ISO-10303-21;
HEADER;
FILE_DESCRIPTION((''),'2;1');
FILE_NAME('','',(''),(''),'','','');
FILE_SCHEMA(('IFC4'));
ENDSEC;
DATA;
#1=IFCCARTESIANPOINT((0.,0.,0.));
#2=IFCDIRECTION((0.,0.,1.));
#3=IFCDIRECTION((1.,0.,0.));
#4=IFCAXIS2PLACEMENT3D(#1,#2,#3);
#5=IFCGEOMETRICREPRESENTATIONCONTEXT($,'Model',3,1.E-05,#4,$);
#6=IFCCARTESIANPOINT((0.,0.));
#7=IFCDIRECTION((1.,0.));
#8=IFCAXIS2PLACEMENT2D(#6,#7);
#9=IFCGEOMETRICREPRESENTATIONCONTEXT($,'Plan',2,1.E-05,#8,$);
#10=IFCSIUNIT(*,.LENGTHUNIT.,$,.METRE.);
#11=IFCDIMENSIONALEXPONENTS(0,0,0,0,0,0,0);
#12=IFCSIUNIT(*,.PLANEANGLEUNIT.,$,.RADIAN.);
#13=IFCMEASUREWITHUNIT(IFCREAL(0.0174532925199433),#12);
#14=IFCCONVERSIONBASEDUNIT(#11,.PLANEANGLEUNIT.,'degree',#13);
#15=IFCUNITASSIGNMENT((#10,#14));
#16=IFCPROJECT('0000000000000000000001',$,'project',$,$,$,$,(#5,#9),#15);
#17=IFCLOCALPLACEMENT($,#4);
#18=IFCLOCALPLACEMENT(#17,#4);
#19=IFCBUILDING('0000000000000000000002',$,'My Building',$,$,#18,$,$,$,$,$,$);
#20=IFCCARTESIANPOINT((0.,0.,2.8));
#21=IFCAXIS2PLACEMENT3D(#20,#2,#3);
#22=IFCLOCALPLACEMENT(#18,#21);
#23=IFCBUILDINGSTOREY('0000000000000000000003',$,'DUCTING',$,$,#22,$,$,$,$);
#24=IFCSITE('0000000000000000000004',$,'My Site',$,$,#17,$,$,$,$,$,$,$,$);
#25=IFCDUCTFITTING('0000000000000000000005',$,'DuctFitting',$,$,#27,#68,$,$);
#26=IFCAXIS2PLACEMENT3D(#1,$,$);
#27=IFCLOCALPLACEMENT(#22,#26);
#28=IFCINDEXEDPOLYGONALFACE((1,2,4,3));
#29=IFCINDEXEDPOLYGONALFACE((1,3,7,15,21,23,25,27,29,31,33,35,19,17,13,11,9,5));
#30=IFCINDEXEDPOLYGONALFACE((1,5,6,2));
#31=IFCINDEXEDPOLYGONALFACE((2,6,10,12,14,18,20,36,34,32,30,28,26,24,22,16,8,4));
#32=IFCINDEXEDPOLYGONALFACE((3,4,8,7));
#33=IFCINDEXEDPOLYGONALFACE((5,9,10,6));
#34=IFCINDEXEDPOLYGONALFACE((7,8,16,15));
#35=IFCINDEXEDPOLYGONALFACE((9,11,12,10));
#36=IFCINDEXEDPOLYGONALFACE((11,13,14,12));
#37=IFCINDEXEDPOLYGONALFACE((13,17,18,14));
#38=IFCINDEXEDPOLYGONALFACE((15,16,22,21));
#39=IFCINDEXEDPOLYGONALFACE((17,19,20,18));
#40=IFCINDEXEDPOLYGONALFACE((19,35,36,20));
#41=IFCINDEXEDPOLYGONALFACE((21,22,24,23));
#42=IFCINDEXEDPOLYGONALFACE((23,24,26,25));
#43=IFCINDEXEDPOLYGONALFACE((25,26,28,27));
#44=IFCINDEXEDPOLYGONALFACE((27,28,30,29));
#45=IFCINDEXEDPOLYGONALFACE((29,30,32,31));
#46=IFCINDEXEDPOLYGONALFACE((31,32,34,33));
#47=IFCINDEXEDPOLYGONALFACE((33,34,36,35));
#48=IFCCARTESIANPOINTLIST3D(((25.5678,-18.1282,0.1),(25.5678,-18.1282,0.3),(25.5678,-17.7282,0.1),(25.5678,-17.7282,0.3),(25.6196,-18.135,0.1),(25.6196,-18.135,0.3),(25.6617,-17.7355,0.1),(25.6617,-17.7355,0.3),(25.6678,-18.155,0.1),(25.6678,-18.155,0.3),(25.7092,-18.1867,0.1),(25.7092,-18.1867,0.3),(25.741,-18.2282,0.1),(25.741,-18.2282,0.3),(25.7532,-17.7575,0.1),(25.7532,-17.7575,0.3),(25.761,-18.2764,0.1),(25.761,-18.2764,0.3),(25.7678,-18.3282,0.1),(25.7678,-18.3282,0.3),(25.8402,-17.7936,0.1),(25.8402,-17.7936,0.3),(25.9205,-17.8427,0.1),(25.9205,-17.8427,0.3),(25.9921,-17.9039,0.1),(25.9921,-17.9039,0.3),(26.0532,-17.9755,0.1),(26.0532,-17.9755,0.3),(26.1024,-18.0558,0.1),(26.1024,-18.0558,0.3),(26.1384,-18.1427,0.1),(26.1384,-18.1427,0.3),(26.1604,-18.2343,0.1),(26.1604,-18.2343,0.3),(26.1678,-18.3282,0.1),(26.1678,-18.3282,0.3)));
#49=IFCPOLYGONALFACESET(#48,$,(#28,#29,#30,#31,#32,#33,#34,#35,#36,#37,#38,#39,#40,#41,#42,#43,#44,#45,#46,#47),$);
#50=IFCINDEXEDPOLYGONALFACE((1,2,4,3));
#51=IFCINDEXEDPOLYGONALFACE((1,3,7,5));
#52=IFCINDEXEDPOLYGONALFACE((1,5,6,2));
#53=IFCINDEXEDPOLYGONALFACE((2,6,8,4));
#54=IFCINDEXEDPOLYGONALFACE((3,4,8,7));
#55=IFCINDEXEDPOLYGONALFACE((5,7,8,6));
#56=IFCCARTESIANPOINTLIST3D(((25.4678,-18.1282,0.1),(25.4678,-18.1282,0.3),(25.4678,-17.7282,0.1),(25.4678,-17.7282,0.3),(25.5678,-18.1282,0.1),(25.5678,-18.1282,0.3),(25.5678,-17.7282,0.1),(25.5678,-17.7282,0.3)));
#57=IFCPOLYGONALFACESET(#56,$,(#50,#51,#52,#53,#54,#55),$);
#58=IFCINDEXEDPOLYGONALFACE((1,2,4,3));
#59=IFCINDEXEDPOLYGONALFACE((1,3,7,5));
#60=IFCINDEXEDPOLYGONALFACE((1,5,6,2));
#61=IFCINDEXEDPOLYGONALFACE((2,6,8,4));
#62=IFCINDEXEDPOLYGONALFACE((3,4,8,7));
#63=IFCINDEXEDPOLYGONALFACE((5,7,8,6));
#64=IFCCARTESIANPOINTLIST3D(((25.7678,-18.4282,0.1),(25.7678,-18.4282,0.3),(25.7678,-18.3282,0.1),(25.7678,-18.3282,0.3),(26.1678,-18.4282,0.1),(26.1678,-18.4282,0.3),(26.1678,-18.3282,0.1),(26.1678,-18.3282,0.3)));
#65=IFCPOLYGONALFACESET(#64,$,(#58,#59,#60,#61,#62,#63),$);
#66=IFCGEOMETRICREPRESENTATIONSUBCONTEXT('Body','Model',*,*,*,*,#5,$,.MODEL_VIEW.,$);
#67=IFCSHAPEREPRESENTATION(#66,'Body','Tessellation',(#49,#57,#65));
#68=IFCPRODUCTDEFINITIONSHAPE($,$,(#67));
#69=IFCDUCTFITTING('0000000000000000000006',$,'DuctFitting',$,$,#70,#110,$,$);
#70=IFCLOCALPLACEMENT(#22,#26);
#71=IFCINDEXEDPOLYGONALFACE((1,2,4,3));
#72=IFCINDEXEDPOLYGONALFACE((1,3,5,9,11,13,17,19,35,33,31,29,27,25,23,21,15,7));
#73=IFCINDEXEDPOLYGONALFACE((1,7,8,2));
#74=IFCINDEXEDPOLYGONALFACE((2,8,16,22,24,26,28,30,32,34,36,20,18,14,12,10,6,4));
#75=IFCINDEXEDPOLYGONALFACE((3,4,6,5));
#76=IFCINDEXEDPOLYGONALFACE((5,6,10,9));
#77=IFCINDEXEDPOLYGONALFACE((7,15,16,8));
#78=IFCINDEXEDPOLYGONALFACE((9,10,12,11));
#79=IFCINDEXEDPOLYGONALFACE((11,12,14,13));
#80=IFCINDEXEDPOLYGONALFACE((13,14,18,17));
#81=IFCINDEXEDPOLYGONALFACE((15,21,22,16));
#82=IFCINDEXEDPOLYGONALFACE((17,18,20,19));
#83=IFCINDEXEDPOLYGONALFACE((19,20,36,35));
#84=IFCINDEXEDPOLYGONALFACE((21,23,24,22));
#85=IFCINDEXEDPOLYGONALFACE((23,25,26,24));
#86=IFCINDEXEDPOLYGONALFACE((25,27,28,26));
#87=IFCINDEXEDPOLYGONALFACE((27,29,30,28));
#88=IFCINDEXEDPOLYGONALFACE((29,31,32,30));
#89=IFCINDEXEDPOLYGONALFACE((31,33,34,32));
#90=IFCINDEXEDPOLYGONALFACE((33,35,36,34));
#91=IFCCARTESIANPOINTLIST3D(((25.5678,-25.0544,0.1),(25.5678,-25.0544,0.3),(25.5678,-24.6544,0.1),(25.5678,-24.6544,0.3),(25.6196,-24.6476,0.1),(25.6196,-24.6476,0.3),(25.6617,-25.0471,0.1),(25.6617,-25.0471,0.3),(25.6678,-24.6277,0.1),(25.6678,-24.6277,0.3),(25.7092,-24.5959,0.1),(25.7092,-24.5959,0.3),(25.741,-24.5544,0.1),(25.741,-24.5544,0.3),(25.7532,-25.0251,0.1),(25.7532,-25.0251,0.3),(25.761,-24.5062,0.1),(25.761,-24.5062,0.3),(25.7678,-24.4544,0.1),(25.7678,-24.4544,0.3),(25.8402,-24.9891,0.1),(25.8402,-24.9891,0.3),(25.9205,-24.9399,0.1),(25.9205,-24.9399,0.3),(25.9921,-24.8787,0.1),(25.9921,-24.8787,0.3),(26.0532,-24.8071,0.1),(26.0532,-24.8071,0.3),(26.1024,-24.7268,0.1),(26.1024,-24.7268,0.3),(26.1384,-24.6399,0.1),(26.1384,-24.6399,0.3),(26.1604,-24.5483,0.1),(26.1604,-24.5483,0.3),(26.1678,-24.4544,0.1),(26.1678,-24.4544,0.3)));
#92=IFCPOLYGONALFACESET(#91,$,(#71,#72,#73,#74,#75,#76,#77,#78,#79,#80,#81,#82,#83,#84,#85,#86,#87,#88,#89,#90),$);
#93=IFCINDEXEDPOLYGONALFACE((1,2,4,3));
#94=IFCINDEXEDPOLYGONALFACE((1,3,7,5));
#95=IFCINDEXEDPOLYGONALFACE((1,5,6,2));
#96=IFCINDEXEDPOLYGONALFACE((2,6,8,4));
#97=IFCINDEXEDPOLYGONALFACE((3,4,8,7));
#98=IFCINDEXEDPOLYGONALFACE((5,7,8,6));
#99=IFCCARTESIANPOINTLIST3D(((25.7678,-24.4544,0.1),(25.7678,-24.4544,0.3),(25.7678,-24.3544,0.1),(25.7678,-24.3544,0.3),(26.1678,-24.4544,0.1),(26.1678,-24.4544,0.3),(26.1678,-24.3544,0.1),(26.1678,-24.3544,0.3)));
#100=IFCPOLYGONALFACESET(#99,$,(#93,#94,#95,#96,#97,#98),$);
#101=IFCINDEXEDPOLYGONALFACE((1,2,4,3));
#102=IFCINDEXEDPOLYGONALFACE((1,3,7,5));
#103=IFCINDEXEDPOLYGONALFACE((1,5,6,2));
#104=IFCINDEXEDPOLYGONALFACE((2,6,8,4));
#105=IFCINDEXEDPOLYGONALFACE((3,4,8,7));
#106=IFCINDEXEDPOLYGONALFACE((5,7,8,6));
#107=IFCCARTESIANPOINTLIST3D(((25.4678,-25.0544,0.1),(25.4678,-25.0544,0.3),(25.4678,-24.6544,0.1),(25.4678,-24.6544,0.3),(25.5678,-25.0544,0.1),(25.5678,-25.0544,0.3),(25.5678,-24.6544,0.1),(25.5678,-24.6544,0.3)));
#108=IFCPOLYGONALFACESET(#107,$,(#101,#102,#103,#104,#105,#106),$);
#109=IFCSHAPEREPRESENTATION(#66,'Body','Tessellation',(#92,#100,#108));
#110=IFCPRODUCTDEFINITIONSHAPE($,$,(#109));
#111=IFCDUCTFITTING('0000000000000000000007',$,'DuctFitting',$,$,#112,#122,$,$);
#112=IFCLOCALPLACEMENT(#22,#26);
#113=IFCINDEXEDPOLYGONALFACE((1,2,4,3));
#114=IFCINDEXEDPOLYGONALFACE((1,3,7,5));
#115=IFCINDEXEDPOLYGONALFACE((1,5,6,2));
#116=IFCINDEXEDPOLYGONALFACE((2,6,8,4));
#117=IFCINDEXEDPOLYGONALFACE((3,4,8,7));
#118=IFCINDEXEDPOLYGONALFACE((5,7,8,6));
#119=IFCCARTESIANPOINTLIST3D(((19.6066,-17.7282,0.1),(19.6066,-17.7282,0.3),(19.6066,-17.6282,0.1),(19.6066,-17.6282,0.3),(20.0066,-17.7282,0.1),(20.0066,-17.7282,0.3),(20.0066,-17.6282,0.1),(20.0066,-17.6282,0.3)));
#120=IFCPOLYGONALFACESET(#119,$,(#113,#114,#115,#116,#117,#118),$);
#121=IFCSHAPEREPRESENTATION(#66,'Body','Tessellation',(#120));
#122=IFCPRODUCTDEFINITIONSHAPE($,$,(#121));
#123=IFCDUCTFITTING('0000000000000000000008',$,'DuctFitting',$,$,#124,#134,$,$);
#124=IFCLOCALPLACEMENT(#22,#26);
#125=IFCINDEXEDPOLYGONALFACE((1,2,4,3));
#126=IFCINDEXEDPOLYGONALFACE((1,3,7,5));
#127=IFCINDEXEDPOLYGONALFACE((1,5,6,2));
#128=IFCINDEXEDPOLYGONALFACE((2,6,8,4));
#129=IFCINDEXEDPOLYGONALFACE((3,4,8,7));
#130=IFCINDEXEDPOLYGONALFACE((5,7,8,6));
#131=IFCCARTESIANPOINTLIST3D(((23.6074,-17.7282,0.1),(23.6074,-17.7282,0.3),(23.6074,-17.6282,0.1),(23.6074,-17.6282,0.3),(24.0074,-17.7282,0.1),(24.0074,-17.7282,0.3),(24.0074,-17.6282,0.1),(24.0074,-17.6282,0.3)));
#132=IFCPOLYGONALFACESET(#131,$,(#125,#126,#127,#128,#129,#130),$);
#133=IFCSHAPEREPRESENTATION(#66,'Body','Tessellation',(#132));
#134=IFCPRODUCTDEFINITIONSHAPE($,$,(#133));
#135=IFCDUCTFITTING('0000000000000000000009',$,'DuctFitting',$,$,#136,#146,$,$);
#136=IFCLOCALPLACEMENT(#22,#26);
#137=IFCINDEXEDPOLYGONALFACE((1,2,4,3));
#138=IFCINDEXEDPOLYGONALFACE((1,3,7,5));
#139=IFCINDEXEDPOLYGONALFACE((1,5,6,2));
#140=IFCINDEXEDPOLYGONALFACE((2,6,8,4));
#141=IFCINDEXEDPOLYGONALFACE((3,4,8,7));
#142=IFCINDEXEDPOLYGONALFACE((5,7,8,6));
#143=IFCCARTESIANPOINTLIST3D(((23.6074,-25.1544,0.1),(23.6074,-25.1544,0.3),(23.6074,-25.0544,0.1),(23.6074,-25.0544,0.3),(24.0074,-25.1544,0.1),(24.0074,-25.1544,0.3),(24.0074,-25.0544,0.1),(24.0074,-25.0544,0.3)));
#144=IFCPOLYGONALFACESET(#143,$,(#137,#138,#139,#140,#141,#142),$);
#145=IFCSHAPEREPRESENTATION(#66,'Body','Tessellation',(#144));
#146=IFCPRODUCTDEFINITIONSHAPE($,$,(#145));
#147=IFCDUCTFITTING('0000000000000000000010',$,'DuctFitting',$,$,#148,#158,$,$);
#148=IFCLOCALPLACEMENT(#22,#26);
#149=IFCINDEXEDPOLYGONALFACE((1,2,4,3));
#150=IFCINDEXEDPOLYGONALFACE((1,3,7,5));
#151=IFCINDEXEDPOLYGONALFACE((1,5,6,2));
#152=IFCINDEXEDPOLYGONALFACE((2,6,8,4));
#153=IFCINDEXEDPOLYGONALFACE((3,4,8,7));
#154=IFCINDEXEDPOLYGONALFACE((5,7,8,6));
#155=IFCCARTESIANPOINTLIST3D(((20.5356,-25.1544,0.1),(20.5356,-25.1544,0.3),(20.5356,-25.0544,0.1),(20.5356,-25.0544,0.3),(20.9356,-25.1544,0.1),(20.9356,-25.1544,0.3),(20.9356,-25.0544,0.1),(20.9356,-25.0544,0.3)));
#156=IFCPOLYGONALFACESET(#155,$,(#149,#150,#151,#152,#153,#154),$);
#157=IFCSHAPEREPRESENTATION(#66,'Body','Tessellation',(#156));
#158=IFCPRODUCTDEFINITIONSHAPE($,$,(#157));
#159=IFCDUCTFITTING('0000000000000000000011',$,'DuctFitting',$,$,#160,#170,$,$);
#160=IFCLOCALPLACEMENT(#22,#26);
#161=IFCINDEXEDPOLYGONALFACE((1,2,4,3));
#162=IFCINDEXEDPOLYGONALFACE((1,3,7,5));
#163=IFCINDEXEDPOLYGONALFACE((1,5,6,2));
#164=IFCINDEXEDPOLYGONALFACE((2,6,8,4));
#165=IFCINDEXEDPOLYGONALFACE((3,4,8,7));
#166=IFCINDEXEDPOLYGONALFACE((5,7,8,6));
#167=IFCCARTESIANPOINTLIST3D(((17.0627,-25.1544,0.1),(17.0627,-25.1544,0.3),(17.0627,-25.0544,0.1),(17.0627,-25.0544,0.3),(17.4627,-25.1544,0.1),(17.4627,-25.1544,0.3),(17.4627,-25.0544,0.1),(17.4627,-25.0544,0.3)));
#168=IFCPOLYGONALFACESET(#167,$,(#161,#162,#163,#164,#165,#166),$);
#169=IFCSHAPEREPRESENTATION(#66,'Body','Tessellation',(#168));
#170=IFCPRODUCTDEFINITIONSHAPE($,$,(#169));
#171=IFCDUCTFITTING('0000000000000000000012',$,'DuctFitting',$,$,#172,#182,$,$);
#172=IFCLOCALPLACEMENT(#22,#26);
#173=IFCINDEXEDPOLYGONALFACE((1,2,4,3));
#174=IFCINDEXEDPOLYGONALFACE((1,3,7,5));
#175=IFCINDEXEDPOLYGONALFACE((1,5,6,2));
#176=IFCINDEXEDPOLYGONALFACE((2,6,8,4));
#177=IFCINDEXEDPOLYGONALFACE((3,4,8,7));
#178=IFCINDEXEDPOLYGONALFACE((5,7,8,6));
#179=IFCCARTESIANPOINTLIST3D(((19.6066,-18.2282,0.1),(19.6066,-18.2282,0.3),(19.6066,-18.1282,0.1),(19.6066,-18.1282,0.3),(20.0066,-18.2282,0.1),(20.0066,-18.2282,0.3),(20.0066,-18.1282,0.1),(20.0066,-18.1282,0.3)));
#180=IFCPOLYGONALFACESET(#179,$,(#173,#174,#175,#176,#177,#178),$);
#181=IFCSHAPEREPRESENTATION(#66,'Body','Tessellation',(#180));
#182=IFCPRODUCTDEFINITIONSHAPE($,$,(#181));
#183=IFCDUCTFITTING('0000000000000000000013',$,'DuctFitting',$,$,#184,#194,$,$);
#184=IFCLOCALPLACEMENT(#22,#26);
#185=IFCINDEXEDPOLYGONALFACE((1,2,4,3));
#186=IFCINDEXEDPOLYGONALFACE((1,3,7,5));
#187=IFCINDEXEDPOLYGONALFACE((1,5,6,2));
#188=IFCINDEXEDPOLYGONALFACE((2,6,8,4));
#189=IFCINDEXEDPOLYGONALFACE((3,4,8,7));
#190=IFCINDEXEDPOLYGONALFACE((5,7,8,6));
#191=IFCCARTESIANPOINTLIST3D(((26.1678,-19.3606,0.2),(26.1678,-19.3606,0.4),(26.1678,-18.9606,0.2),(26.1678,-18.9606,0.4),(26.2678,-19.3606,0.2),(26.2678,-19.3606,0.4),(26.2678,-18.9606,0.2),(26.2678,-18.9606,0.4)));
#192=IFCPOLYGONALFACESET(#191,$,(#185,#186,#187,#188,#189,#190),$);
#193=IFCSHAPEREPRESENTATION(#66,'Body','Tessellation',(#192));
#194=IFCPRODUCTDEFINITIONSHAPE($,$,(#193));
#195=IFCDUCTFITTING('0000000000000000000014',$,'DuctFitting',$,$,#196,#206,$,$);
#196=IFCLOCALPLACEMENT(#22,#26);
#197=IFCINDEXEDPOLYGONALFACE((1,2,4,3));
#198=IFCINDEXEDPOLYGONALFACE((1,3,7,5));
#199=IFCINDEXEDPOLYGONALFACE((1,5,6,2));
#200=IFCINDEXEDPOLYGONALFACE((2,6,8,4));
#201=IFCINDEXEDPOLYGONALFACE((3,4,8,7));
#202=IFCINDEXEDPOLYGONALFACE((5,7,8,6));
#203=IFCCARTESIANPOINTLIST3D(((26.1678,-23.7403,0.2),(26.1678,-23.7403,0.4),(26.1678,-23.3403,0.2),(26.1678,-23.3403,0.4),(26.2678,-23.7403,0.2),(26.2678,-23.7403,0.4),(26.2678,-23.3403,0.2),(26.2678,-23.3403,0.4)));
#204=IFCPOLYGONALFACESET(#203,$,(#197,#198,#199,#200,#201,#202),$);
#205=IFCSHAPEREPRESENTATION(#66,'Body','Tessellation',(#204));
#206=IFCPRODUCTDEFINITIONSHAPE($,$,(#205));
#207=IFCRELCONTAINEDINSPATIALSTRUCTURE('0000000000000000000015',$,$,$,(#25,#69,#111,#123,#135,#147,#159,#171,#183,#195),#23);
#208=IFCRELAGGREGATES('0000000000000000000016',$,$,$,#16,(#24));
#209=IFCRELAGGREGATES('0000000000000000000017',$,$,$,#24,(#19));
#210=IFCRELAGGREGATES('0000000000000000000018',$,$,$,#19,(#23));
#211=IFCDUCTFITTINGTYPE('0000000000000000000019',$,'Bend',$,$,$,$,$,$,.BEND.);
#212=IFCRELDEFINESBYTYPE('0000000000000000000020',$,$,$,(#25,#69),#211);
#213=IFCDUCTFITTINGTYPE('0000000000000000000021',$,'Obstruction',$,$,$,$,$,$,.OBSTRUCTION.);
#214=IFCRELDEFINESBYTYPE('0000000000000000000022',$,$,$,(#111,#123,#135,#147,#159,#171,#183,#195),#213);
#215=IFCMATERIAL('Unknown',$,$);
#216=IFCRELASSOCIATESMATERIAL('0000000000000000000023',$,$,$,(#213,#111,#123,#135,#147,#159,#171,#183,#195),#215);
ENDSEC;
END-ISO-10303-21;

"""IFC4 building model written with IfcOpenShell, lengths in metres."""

from ifc_helpers import new_model, entity, si_unit, converted_unit, frame, origin_with_axes, origin_2d_with_axis, place, context, subcontext, project, spatial, line, arc, indexed_curve, rectangle, outline, extrude, source, transform, mapped, material, material_profile, profile_set, profile_usage, type_object, type_shapes, element, save


model = new_model("IFC4")

# Units and contexts
model_context = context("Model", 3, precision=1e-05, world=origin_with_axes())
plan_context = context("Plan", 2, precision=1e-05, world=origin_2d_with_axis())
body_context = subcontext(model_context, "Body", "Model", "MODEL_VIEW")
ifc_project = project(units=[si_unit("LENGTHUNIT", "METRE"), converted_unit("PLANEANGLEUNIT", "degree", entity("IfcReal", 0.0174532925199433), si_unit("PLANEANGLEUNIT", "RADIAN"), dimensions=[0, 0, 0, 0, 0, 0, 0])], contexts=[model_context, plan_context])

# Site, building, storey
site_placement = place(None, origin_with_axes())
site = spatial("IfcSite", under=ifc_project, at=site_placement, Name="My Site")
building_placement = place(site_placement, origin_with_axes())
building = spatial("IfcBuilding", under=site, at=building_placement, Name="My Building")
storey_placement = place(building_placement, frame((0.0, 0.0, 2.8), z_axis=(0.0, 0.0, 1.0), x_axis=(1.0, 0.0, 0.0)))
storey = spatial("IfcBuildingStorey", under=building, at=storey_placement, Name="DUCTING")

# Shared definitions
ifc_material = material(Name="Unknown")

# Duct fittings
duct_fitting_type_1 = type_object("IfcDuctFittingType", Name="Bend", PredefinedType="BEND")
shared_shape = source(origin_with_axes(), body_context, "Body", "SweptSolid", [
    extrude(outline(indexed_curve([(-0.2, 0.0), (-0.2586, 0.1414), (-0.4, 0.2), (-0.4, 0.6), (0.0243, 0.4243), (0.2, 0.0)], segments=[arc(1, 2, 3), line(3, 4), arc(4, 5, 6), line(6, 1)])), frame((0.0, -0.1, 0.1), z_axis=(0.0, -1.0, 0.0), x_axis=(1.0, 0.0, 0.0)), (0.0, 0.0, -1.0), 0.2),
    extrude(rectangle(XDim=0.4, YDim=0.2), origin_with_axes(), (0.0, 0.0, 1.0), 0.1),
    extrude(rectangle(XDim=0.4, YDim=0.2), frame((-0.4, 0.0, 0.5), z_axis=(-1.0, 0.0, 0.0), x_axis=(0.0, 0.0, -1.0)), (0.0, 0.0, 1.0), 0.1),
])
type_shapes(duct_fitting_type_1, [shared_shape])
for number, where, z_axis, x_axis, name in (
    (1, (25.4678, -17.9282, 0.2), (1.0, 0.0, 0.0), (0.0, 1.0, 0.0), "DuctFitting"),
    (2, (25.9678, -24.3544, 0.2), (0.0, -1.0, 0.0), (1.0, 0.0, 0.0), "DuctFitting"),
):
    element("IfcDuctFitting", number, at=place(storey_placement, frame(where, z_axis=z_axis, x_axis=x_axis)), inside=storey, type_object=duct_fitting_type_1, Name=name, context=body_context, shape_type="MappedRepresentation", body=[
        mapped(shared_shape, transform((0.0, 0.0, 0.0), x_axis=(1.0, 0.0, 0.0), y_axis=(0.0, 1.0, 0.0), z_axis=(0.0, 0.0, 1.0), scale=1.0)),
    ])
ifc_material_profile_1 = material_profile(ifc_material, rectangle(XDim=0.4, YDim=0.2))
ifc_profile_set_1 = profile_set([ifc_material_profile_1])
ifc_profile_usage_1 = profile_usage(ifc_profile_set_1, cardinal=5)
duct_fitting_type_2 = type_object("IfcDuctFittingType", Name="Obstruction", PredefinedType="OBSTRUCTION", material=ifc_profile_set_1)
duct_fitting_1_placement = place(storey_placement, frame((19.8066, -17.6282, 0.2), z_axis=(0.0, -1.0, 0.0), x_axis=(1.0, 0.0, 0.0)))
element("IfcDuctFitting", 3, at=duct_fitting_1_placement, inside=storey, type_object=duct_fitting_type_2, material=ifc_profile_usage_1, Name="DuctFitting", context=body_context, shape_type="SweptSolid", body=[
    extrude(rectangle(XDim=0.4, YDim=0.2), origin_with_axes(), (0.0, 0.0, 1.0), 0.1),
])
ifc_profile_usage_2 = profile_usage(ifc_profile_set_1, cardinal=5)
duct_fitting_2_placement = place(storey_placement, frame((23.8074, -17.6282, 0.2), z_axis=(0.0, -1.0, 0.0), x_axis=(1.0, 0.0, 0.0)))
element("IfcDuctFitting", 4, at=duct_fitting_2_placement, inside=storey, type_object=duct_fitting_type_2, material=ifc_profile_usage_2, Name="DuctFitting", context=body_context, shape_type="SweptSolid", body=[
    extrude(rectangle(XDim=0.4, YDim=0.2), origin_with_axes(), (0.0, 0.0, 1.0), 0.1),
])
ifc_profile_usage_3 = profile_usage(ifc_profile_set_1, cardinal=5)
duct_fitting_3_placement = place(storey_placement, frame((23.8074, -25.1544, 0.2), z_axis=(0.000001, 1.0, 0.0), x_axis=(-1.0, 0.000001, 0.0)))
element("IfcDuctFitting", 5, at=duct_fitting_3_placement, inside=storey, type_object=duct_fitting_type_2, material=ifc_profile_usage_3, Name="DuctFitting", context=body_context, shape_type="SweptSolid", body=[
    extrude(rectangle(XDim=0.4, YDim=0.2), origin_with_axes(), (0.0, 0.0, 1.0), 0.1),
])
ifc_profile_usage_4 = profile_usage(ifc_profile_set_1, cardinal=5)
duct_fitting_4_placement = place(storey_placement, frame((20.7356, -25.1544, 0.2), z_axis=(0.000001, 1.0, 0.0), x_axis=(-1.0, 0.000001, 0.0)))
element("IfcDuctFitting", 6, at=duct_fitting_4_placement, inside=storey, type_object=duct_fitting_type_2, material=ifc_profile_usage_4, Name="DuctFitting", context=body_context, shape_type="SweptSolid", body=[
    extrude(rectangle(XDim=0.4, YDim=0.2), origin_with_axes(), (0.0, 0.0, 1.0), 0.1),
])
ifc_profile_usage_5 = profile_usage(ifc_profile_set_1, cardinal=5)
duct_fitting_5_placement = place(storey_placement, frame((17.2627, -25.1544, 0.2), z_axis=(0.000001, 1.0, 0.0), x_axis=(-1.0, 0.000001, 0.0)))
element("IfcDuctFitting", 7, at=duct_fitting_5_placement, inside=storey, type_object=duct_fitting_type_2, material=ifc_profile_usage_5, Name="DuctFitting", context=body_context, shape_type="SweptSolid", body=[
    extrude(rectangle(XDim=0.4, YDim=0.2), origin_with_axes(), (0.0, 0.0, 1.0), 0.1),
])
ifc_profile_usage_6 = profile_usage(ifc_profile_set_1, cardinal=5)
duct_fitting_6_placement = place(storey_placement, frame((19.8066, -18.2282, 0.2), z_axis=(0.000001, 1.0, 0.0), x_axis=(-1.0, 0.000001, 0.0)))
element("IfcDuctFitting", 8, at=duct_fitting_6_placement, inside=storey, type_object=duct_fitting_type_2, material=ifc_profile_usage_6, Name="DuctFitting", context=body_context, shape_type="SweptSolid", body=[
    extrude(rectangle(XDim=0.4, YDim=0.2), origin_with_axes(), (0.0, 0.0, 1.0), 0.1),
])
ifc_profile_usage_7 = profile_usage(ifc_profile_set_1, cardinal=5)
duct_fitting_7_placement = place(storey_placement, frame((26.1678, -19.1606, 0.3), z_axis=(1.0, 0.0, 0.0), x_axis=(0.0, 1.0, 0.0)))
element("IfcDuctFitting", 9, at=duct_fitting_7_placement, inside=storey, type_object=duct_fitting_type_2, material=ifc_profile_usage_7, Name="DuctFitting", context=body_context, shape_type="SweptSolid", body=[
    extrude(rectangle(XDim=0.4, YDim=0.2), origin_with_axes(), (0.0, 0.0, 1.0), 0.1),
])
ifc_profile_usage_8 = profile_usage(ifc_profile_set_1, cardinal=5)
duct_fitting_8_placement = place(storey_placement, frame((26.1678, -23.5403, 0.3), z_axis=(1.0, 0.0, 0.0), x_axis=(0.0, 1.0, 0.0)))
element("IfcDuctFitting", 10, at=duct_fitting_8_placement, inside=storey, type_object=duct_fitting_type_2, material=ifc_profile_usage_8, Name="DuctFitting", context=body_context, shape_type="SweptSolid", body=[
    extrude(rectangle(XDim=0.4, YDim=0.2), origin_with_axes(), (0.0, 0.0, 1.0), 0.1),
])

save(model, "model.ifc")
